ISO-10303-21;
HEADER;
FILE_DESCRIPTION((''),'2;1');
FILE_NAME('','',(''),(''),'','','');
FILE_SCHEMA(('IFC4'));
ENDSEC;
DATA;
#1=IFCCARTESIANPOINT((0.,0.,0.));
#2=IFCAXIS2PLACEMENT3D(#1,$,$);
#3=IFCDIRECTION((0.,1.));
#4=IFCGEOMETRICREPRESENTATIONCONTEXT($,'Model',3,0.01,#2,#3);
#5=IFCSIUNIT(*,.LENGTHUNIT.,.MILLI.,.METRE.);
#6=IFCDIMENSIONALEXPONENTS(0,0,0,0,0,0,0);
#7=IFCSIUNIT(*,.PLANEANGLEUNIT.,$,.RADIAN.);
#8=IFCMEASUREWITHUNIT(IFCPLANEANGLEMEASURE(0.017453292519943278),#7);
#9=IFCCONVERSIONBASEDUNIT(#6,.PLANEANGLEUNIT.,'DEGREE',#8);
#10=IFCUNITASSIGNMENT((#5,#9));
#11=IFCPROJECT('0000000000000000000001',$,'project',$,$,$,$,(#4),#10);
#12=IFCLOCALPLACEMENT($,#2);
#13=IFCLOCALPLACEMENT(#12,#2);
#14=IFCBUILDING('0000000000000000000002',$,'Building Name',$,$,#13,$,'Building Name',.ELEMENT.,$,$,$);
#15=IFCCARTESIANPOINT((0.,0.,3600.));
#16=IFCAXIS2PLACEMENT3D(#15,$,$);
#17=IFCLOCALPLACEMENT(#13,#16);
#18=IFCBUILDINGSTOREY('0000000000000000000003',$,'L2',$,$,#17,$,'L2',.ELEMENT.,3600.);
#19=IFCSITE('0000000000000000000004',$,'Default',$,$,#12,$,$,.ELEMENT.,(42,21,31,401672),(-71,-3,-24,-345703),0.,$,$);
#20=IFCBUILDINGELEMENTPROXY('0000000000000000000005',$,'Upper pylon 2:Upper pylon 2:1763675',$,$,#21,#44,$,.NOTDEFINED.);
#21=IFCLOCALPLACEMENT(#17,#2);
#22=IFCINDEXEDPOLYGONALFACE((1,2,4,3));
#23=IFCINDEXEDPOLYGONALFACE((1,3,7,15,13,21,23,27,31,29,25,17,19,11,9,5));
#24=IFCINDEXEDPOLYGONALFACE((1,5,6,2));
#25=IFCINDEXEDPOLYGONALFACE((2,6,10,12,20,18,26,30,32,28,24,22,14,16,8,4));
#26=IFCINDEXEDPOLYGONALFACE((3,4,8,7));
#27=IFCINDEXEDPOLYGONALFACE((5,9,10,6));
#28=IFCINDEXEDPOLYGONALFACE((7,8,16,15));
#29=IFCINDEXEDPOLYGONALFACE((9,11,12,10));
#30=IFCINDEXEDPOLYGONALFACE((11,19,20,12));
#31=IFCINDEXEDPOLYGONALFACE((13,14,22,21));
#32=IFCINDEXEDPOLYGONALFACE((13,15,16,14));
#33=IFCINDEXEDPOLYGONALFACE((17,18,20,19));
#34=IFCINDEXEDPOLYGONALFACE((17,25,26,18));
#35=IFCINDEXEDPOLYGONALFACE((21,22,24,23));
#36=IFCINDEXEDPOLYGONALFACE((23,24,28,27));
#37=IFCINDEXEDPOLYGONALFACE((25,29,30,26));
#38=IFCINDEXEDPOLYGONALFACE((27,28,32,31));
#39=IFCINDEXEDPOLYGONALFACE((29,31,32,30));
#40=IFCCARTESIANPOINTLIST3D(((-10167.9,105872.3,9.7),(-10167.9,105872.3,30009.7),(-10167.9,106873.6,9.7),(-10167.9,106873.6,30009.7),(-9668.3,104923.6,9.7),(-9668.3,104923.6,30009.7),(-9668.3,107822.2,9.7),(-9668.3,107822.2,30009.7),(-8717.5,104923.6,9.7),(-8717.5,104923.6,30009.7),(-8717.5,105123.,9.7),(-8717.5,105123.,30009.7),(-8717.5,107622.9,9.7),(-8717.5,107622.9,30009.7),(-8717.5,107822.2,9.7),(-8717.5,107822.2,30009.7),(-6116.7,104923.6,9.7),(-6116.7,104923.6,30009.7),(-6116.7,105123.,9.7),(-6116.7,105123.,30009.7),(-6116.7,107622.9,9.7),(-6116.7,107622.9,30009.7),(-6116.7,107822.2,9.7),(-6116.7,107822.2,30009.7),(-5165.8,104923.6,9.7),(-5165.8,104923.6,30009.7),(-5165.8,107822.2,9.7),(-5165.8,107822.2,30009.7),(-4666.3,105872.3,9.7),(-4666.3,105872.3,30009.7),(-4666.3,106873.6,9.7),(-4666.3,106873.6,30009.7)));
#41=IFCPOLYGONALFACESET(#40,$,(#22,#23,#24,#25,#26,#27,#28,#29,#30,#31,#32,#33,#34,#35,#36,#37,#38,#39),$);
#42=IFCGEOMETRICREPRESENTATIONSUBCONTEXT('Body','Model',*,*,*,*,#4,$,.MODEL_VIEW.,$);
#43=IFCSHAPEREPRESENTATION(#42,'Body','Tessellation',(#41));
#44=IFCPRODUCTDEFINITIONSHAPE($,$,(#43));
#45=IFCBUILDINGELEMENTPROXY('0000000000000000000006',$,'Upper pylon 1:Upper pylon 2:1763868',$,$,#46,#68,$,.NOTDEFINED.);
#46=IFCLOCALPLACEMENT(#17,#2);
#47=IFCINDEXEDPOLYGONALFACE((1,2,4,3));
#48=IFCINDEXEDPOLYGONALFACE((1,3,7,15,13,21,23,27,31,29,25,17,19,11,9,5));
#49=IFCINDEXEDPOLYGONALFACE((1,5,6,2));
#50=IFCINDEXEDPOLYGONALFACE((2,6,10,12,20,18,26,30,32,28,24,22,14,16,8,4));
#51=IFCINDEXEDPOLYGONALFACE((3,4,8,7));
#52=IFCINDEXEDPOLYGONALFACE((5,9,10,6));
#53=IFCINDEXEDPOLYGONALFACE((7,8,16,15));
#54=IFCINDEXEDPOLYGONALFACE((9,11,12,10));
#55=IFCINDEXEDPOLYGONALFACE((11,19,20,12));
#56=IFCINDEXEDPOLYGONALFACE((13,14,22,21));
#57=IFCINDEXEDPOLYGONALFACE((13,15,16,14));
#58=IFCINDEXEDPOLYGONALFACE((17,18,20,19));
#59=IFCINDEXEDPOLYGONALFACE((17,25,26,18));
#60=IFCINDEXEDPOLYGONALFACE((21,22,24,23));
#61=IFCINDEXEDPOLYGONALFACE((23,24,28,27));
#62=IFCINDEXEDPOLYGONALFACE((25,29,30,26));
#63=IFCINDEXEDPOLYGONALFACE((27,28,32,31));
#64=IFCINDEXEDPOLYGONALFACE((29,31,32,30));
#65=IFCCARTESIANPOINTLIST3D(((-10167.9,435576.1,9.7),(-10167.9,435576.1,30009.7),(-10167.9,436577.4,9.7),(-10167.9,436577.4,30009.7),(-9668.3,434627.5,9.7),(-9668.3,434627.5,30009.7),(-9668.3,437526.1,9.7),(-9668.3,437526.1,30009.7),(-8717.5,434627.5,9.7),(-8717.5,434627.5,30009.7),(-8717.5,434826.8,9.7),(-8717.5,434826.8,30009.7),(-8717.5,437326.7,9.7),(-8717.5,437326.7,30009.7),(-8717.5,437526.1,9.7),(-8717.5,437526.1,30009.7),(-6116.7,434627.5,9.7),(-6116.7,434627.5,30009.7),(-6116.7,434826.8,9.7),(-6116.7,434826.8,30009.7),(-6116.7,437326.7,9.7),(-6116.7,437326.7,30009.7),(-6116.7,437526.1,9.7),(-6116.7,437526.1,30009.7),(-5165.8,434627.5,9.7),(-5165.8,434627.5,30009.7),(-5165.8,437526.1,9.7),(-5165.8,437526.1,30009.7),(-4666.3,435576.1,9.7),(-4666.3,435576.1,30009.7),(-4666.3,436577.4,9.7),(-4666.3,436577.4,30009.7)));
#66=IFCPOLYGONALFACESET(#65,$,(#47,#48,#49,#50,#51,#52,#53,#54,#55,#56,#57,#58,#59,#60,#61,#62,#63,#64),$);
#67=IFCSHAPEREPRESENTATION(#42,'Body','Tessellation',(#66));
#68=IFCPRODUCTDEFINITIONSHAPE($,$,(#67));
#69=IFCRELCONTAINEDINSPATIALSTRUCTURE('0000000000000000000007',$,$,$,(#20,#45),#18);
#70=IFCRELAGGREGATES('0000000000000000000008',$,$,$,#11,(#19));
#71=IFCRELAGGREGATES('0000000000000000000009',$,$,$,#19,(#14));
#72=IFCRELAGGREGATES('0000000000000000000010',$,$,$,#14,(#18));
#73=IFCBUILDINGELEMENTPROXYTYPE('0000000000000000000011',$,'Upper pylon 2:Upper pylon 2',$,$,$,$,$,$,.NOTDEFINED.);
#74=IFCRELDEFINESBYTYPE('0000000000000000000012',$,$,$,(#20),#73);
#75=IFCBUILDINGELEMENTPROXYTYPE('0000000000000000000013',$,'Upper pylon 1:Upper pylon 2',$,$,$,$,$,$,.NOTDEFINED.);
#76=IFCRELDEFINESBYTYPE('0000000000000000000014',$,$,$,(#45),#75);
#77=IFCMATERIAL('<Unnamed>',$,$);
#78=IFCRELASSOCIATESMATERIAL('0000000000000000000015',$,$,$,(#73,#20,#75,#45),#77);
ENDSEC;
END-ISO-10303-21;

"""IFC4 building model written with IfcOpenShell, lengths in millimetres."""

from ifc_helpers import new_model, entity, si_unit, converted_unit, direction, frame, origin, place, context, subcontext, project, spatial, indexed_curve, outline, extrude, source, transform, mapped, material, type_object, type_shapes, element, save


model = new_model("IFC4")

# Units and contexts
model_context = context("Model", 3, precision=0.01, world=origin(), true_north=direction((0.0, 1.0)))
body_context = subcontext(model_context, "Body", "Model", "MODEL_VIEW")
ifc_project = project(units=[si_unit("LENGTHUNIT", "METRE", prefix="MILLI"), converted_unit("PLANEANGLEUNIT", "DEGREE", entity("IfcPlaneAngleMeasure", 0.017453292519943278), si_unit("PLANEANGLEUNIT", "RADIAN"), dimensions=[0, 0, 0, 0, 0, 0, 0])], contexts=[model_context])

# Site, building, storey
site_placement = place(None, origin())
site = spatial("IfcSite", under=ifc_project, at=site_placement, Name="Default", CompositionType="ELEMENT", RefLatitude=(42, 21, 31, 401672), RefLongitude=(-71, -3, -24, -345703), RefElevation=0.0)
building_placement = place(site_placement, origin())
building = spatial("IfcBuilding", under=site, at=building_placement, Name="Building Name", LongName="Building Name", CompositionType="ELEMENT")
storey_placement = place(building_placement, frame((0.0, 0.0, 3600.0)))
storey = spatial("IfcBuildingStorey", under=building, at=storey_placement, Name="L2", LongName="L2", CompositionType="ELEMENT", Elevation=3600.0)

# Building element proxies
ifc_material = material(Name="<Unnamed>")
building_element_proxy_type_1 = type_object("IfcBuildingElementProxyType", Name="Upper pylon 2:Upper pylon 2", PredefinedType="NOTDEFINED", material=ifc_material)
shared_shape_1 = source(origin(), body_context, "Body", "SweptSolid", [
    extrude(outline(indexed_curve([(1300.4, -1449.3), (2251.3, -1449.3), (2750.8, -500.6), (2750.8, 500.6), (2251.3, 1449.3), (1300.4, 1449.3), (1300.4, 1249.9), (-1300.4, 1249.9), (-1300.4, 1449.3), (-2251.3, 1449.3), (-2750.8, 500.6), (-2750.8, -500.6), (-2251.3, -1449.3), (-1300.4, -1449.3), (-1300.4, -1249.9), (1300.4, -1249.9), (1300.4, -1449.3)], self_intersect=False)), frame((68629.5, 106372.9, 3609.7), z_axis=(0.0, 0.0, 1.0), x_axis=(-1.0, 0.0, 0.0)), (0.0, 0.0, 1.0), 30000.0),
])
type_shapes(building_element_proxy_type_1, [shared_shape_1])
proxy_1_placement = place(storey_placement, frame((-76046.6, 0.0, -3600.0)))
element("IfcBuildingElementProxy", 1, at=proxy_1_placement, inside=storey, type_object=building_element_proxy_type_1, material=ifc_material, Name="Upper pylon 2:Upper pylon 2:1763675", PredefinedType="NOTDEFINED", context=body_context, shape_type="MappedRepresentation", body=[
    mapped(shared_shape_1, transform((0.0, 0.0, 0.0), scale=1.0)),
])
building_element_proxy_type_2 = type_object("IfcBuildingElementProxyType", Name="Upper pylon 1:Upper pylon 2", PredefinedType="NOTDEFINED", material=ifc_material)
shared_shape_2 = source(origin(), body_context, "Body", "SweptSolid", [
    extrude(outline(indexed_curve([(1300.4, -1449.3), (2251.3, -1449.3), (2750.8, -500.6), (2750.8, 500.6), (2251.3, 1449.3), (1300.4, 1449.3), (1300.4, 1249.9), (-1300.4, 1249.9), (-1300.4, 1449.3), (-2251.3, 1449.3), (-2750.8, 500.6), (-2750.8, -500.6), (-2251.3, -1449.3), (-1300.4, -1449.3), (-1300.4, -1249.9), (1300.4, -1249.9), (1300.4, -1449.3)], self_intersect=False)), frame((68629.5, 106372.9, 3609.7), z_axis=(0.0, 0.0, 1.0), x_axis=(-1.0, 0.0, 0.0)), (0.0, 0.0, 1.0), 30000.0),
])
type_shapes(building_element_proxy_type_2, [shared_shape_2])
proxy_2_placement = place(storey_placement, frame((-76046.6, 329703.8, -3600.0)))
element("IfcBuildingElementProxy", 2, at=proxy_2_placement, inside=storey, type_object=building_element_proxy_type_2, material=ifc_material, Name="Upper pylon 1:Upper pylon 2:1763868", PredefinedType="NOTDEFINED", context=body_context, shape_type="MappedRepresentation", body=[
    mapped(shared_shape_2, transform((0.0, 0.0, 0.0), scale=1.0)),
])

save(model, "model.ifc")
